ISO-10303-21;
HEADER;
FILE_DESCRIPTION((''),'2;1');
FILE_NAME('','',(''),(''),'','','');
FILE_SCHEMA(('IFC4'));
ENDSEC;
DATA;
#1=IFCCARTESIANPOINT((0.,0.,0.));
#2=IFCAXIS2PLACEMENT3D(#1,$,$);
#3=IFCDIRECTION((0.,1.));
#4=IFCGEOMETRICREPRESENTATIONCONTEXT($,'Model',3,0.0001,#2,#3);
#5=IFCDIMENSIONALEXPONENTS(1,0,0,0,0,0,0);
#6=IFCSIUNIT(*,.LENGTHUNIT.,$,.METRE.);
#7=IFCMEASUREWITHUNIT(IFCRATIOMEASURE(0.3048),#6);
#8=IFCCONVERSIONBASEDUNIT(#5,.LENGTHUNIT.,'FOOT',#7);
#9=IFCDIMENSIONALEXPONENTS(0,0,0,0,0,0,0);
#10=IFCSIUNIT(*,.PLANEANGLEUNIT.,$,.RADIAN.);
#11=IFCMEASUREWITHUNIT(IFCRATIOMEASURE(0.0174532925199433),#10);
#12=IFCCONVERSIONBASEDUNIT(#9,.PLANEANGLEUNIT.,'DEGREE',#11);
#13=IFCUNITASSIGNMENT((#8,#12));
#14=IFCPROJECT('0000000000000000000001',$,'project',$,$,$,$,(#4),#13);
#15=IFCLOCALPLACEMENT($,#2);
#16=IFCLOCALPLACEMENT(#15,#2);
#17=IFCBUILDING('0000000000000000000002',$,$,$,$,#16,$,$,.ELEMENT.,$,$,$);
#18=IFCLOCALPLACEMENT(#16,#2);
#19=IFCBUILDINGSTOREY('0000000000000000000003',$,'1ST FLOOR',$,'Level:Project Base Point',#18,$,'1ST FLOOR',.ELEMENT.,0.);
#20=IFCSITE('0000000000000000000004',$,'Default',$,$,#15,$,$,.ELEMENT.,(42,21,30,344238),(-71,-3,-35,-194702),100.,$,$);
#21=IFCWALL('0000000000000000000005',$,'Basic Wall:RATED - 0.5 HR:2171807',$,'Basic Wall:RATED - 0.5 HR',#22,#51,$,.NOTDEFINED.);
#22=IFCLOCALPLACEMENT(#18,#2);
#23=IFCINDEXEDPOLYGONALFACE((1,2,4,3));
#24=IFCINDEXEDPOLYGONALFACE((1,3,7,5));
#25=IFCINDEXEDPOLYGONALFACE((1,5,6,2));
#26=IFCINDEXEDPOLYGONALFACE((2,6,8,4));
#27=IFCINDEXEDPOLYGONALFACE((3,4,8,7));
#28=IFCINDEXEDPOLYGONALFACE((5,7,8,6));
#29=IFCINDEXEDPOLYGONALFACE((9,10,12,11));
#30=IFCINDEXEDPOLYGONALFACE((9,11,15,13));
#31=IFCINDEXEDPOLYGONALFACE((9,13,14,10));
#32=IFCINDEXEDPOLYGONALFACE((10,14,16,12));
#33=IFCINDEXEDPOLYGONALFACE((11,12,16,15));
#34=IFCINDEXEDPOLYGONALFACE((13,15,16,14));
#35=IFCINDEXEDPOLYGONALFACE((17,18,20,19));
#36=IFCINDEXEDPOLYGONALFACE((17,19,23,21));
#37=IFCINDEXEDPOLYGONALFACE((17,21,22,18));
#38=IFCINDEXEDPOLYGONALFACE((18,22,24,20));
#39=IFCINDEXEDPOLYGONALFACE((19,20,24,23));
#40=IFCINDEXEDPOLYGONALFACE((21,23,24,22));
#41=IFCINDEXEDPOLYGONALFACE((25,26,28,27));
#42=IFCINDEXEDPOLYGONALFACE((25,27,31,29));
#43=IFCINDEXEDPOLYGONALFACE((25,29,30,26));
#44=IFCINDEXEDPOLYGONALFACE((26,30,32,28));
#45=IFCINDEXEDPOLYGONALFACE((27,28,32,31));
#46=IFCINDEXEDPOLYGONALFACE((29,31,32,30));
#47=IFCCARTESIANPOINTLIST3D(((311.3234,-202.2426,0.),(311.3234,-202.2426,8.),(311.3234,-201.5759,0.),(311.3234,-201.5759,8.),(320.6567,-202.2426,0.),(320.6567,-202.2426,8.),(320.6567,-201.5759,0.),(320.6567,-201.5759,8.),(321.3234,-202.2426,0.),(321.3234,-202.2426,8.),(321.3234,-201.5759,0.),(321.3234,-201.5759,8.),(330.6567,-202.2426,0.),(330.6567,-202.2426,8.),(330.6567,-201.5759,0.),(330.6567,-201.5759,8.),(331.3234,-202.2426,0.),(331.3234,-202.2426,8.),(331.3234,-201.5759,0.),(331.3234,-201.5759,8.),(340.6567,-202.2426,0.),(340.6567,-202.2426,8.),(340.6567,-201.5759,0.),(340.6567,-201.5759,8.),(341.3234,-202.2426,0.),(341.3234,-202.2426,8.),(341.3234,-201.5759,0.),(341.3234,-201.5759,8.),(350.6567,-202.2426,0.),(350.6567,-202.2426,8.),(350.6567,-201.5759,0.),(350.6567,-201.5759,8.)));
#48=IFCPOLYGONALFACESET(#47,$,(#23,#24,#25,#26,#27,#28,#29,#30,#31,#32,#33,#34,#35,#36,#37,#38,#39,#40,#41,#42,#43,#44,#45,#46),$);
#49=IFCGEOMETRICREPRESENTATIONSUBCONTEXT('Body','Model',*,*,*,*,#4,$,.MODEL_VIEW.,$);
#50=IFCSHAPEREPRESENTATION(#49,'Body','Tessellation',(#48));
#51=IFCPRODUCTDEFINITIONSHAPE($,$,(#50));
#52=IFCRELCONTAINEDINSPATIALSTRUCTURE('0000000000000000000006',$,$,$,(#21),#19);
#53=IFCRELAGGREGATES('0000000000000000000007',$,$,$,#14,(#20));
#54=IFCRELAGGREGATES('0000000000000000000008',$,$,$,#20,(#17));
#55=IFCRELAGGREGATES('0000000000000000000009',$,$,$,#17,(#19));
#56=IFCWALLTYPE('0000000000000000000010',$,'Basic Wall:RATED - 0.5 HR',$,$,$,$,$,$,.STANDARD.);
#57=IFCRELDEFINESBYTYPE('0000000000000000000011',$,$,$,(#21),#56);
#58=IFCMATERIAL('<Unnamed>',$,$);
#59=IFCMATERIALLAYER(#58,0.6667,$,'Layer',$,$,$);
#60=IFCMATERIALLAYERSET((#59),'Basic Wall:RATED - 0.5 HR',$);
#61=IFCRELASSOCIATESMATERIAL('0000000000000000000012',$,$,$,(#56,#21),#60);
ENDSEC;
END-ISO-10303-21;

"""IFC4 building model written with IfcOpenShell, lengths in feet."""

from ifc_helpers import new_model, entity, si_unit, converted_unit, direction, frame, frame_2d, origin, place, context, subcontext, project, spatial, rectangle, extrude, material, layer, layer_set, layer_usage, type_object, element, save


model = new_model("IFC4")

# Units and contexts
model_context = context("Model", 3, precision=0.0001, world=origin(), true_north=direction((0.0, 1.0)))
body_context = subcontext(model_context, "Body", "Model", "MODEL_VIEW")
ifc_project = project(units=[converted_unit("LENGTHUNIT", "FOOT", entity("IfcRatioMeasure", 0.3048), si_unit("LENGTHUNIT", "METRE"), dimensions=[1, 0, 0, 0, 0, 0, 0]), converted_unit("PLANEANGLEUNIT", "DEGREE", entity("IfcRatioMeasure", 0.0174532925199433), si_unit("PLANEANGLEUNIT", "RADIAN"), dimensions=[0, 0, 0, 0, 0, 0, 0])], contexts=[model_context])

# Site, building, storey
site_placement = place(None, origin())
site = spatial("IfcSite", under=ifc_project, at=site_placement, Name="Default", CompositionType="ELEMENT", RefLatitude=(42, 21, 30, 344238), RefLongitude=(-71, -3, -35, -194702), RefElevation=100.0)
building_placement = place(site_placement, origin())
building = spatial("IfcBuilding", under=site, at=building_placement, CompositionType="ELEMENT")
storey_placement = place(building_placement, origin())
storey = spatial("IfcBuildingStorey", under=building, at=storey_placement, Name="1ST FLOOR", ObjectType="Level:Project Base Point", LongName="1ST FLOOR", CompositionType="ELEMENT", Elevation=0.0)

# Shared definitions
ifc_material_1 = material(Name="<Unnamed>")

# Shared definitions
ifc_layer = layer(ifc_material_1, 0.6667, Name="Layer")
ifc_layer_set = layer_set([ifc_layer], Name="Basic Wall:RATED - 0.5 HR")
wall_type = type_object("IfcWallType", Name="Basic Wall:RATED - 0.5 HR", PredefinedType="STANDARD", material=ifc_layer_set)

# Wall, openings
ifc_layer_usage_1 = layer_usage(ifc_layer_set, "AXIS2", "NEGATIVE", 0.3333)
wall_1_placement = place(storey_placement, frame((311.3234, -201.9092, 0.0)))
wall_1 = element("IfcWall", 1, at=wall_1_placement, inside=storey, type_object=wall_type, material=ifc_layer_usage_1, Name="Basic Wall:RATED - 0.5 HR:2171807", ObjectType="Basic Wall:RATED - 0.5 HR", PredefinedType="NOTDEFINED", context=body_context, shape_type="SweptSolid", body=[
    extrude(rectangle(XDim=39.3333, YDim=0.6667, at=frame_2d((19.6667, 0.0), x_axis=(-1.0, 0.0))), origin(), (0.0, 0.0, 1.0), 8.0),
])
opening_1_placement = place(storey_placement, frame((311.3234, -201.9092, 0.0)))
element("IfcOpeningElement", 2, at=opening_1_placement, cuts=wall_1, PredefinedType="OPENING", context=body_context, shape_type="SweptSolid", body=[
    extrude(rectangle(XDim=8.0, YDim=0.6667, at=frame_2d((0.0, 0.0), x_axis=(1.0, 0.0))), frame((29.3333, 0.0, 4.0), z_axis=(1.0, 0.0, 0.0), x_axis=(0.0, 0.0, -1.0)), (0.0, 0.0, 1.0), 0.6667),
])
opening_2_placement = place(storey_placement, frame((311.3234, -201.9092, 0.0)))
element("IfcOpeningElement", 3, at=opening_2_placement, cuts=wall_1, PredefinedType="OPENING", context=body_context, shape_type="SweptSolid", body=[
    extrude(rectangle(XDim=8.0, YDim=0.6667, at=frame_2d((0.0, 0.0), x_axis=(1.0, 0.0))), frame((19.3333, 0.0, 4.0), z_axis=(1.0, 0.0, 0.0), x_axis=(0.0, 0.0, -1.0)), (0.0, 0.0, 1.0), 0.6667),
])
opening_3_placement = place(storey_placement, frame((311.3234, -201.9092, 0.0)))
element("IfcOpeningElement", 4, at=opening_3_placement, cuts=wall_1, PredefinedType="OPENING", context=body_context, shape_type="SweptSolid", body=[
    extrude(rectangle(XDim=8.0, YDim=0.6667, at=frame_2d((0.0, 0.0), x_axis=(1.0, 0.0))), frame((9.3333, 0.0, 4.0), z_axis=(1.0, 0.0, 0.0), x_axis=(0.0, 0.0, -1.0)), (0.0, 0.0, 1.0), 0.6667),
])

save(model, "model.ifc")
